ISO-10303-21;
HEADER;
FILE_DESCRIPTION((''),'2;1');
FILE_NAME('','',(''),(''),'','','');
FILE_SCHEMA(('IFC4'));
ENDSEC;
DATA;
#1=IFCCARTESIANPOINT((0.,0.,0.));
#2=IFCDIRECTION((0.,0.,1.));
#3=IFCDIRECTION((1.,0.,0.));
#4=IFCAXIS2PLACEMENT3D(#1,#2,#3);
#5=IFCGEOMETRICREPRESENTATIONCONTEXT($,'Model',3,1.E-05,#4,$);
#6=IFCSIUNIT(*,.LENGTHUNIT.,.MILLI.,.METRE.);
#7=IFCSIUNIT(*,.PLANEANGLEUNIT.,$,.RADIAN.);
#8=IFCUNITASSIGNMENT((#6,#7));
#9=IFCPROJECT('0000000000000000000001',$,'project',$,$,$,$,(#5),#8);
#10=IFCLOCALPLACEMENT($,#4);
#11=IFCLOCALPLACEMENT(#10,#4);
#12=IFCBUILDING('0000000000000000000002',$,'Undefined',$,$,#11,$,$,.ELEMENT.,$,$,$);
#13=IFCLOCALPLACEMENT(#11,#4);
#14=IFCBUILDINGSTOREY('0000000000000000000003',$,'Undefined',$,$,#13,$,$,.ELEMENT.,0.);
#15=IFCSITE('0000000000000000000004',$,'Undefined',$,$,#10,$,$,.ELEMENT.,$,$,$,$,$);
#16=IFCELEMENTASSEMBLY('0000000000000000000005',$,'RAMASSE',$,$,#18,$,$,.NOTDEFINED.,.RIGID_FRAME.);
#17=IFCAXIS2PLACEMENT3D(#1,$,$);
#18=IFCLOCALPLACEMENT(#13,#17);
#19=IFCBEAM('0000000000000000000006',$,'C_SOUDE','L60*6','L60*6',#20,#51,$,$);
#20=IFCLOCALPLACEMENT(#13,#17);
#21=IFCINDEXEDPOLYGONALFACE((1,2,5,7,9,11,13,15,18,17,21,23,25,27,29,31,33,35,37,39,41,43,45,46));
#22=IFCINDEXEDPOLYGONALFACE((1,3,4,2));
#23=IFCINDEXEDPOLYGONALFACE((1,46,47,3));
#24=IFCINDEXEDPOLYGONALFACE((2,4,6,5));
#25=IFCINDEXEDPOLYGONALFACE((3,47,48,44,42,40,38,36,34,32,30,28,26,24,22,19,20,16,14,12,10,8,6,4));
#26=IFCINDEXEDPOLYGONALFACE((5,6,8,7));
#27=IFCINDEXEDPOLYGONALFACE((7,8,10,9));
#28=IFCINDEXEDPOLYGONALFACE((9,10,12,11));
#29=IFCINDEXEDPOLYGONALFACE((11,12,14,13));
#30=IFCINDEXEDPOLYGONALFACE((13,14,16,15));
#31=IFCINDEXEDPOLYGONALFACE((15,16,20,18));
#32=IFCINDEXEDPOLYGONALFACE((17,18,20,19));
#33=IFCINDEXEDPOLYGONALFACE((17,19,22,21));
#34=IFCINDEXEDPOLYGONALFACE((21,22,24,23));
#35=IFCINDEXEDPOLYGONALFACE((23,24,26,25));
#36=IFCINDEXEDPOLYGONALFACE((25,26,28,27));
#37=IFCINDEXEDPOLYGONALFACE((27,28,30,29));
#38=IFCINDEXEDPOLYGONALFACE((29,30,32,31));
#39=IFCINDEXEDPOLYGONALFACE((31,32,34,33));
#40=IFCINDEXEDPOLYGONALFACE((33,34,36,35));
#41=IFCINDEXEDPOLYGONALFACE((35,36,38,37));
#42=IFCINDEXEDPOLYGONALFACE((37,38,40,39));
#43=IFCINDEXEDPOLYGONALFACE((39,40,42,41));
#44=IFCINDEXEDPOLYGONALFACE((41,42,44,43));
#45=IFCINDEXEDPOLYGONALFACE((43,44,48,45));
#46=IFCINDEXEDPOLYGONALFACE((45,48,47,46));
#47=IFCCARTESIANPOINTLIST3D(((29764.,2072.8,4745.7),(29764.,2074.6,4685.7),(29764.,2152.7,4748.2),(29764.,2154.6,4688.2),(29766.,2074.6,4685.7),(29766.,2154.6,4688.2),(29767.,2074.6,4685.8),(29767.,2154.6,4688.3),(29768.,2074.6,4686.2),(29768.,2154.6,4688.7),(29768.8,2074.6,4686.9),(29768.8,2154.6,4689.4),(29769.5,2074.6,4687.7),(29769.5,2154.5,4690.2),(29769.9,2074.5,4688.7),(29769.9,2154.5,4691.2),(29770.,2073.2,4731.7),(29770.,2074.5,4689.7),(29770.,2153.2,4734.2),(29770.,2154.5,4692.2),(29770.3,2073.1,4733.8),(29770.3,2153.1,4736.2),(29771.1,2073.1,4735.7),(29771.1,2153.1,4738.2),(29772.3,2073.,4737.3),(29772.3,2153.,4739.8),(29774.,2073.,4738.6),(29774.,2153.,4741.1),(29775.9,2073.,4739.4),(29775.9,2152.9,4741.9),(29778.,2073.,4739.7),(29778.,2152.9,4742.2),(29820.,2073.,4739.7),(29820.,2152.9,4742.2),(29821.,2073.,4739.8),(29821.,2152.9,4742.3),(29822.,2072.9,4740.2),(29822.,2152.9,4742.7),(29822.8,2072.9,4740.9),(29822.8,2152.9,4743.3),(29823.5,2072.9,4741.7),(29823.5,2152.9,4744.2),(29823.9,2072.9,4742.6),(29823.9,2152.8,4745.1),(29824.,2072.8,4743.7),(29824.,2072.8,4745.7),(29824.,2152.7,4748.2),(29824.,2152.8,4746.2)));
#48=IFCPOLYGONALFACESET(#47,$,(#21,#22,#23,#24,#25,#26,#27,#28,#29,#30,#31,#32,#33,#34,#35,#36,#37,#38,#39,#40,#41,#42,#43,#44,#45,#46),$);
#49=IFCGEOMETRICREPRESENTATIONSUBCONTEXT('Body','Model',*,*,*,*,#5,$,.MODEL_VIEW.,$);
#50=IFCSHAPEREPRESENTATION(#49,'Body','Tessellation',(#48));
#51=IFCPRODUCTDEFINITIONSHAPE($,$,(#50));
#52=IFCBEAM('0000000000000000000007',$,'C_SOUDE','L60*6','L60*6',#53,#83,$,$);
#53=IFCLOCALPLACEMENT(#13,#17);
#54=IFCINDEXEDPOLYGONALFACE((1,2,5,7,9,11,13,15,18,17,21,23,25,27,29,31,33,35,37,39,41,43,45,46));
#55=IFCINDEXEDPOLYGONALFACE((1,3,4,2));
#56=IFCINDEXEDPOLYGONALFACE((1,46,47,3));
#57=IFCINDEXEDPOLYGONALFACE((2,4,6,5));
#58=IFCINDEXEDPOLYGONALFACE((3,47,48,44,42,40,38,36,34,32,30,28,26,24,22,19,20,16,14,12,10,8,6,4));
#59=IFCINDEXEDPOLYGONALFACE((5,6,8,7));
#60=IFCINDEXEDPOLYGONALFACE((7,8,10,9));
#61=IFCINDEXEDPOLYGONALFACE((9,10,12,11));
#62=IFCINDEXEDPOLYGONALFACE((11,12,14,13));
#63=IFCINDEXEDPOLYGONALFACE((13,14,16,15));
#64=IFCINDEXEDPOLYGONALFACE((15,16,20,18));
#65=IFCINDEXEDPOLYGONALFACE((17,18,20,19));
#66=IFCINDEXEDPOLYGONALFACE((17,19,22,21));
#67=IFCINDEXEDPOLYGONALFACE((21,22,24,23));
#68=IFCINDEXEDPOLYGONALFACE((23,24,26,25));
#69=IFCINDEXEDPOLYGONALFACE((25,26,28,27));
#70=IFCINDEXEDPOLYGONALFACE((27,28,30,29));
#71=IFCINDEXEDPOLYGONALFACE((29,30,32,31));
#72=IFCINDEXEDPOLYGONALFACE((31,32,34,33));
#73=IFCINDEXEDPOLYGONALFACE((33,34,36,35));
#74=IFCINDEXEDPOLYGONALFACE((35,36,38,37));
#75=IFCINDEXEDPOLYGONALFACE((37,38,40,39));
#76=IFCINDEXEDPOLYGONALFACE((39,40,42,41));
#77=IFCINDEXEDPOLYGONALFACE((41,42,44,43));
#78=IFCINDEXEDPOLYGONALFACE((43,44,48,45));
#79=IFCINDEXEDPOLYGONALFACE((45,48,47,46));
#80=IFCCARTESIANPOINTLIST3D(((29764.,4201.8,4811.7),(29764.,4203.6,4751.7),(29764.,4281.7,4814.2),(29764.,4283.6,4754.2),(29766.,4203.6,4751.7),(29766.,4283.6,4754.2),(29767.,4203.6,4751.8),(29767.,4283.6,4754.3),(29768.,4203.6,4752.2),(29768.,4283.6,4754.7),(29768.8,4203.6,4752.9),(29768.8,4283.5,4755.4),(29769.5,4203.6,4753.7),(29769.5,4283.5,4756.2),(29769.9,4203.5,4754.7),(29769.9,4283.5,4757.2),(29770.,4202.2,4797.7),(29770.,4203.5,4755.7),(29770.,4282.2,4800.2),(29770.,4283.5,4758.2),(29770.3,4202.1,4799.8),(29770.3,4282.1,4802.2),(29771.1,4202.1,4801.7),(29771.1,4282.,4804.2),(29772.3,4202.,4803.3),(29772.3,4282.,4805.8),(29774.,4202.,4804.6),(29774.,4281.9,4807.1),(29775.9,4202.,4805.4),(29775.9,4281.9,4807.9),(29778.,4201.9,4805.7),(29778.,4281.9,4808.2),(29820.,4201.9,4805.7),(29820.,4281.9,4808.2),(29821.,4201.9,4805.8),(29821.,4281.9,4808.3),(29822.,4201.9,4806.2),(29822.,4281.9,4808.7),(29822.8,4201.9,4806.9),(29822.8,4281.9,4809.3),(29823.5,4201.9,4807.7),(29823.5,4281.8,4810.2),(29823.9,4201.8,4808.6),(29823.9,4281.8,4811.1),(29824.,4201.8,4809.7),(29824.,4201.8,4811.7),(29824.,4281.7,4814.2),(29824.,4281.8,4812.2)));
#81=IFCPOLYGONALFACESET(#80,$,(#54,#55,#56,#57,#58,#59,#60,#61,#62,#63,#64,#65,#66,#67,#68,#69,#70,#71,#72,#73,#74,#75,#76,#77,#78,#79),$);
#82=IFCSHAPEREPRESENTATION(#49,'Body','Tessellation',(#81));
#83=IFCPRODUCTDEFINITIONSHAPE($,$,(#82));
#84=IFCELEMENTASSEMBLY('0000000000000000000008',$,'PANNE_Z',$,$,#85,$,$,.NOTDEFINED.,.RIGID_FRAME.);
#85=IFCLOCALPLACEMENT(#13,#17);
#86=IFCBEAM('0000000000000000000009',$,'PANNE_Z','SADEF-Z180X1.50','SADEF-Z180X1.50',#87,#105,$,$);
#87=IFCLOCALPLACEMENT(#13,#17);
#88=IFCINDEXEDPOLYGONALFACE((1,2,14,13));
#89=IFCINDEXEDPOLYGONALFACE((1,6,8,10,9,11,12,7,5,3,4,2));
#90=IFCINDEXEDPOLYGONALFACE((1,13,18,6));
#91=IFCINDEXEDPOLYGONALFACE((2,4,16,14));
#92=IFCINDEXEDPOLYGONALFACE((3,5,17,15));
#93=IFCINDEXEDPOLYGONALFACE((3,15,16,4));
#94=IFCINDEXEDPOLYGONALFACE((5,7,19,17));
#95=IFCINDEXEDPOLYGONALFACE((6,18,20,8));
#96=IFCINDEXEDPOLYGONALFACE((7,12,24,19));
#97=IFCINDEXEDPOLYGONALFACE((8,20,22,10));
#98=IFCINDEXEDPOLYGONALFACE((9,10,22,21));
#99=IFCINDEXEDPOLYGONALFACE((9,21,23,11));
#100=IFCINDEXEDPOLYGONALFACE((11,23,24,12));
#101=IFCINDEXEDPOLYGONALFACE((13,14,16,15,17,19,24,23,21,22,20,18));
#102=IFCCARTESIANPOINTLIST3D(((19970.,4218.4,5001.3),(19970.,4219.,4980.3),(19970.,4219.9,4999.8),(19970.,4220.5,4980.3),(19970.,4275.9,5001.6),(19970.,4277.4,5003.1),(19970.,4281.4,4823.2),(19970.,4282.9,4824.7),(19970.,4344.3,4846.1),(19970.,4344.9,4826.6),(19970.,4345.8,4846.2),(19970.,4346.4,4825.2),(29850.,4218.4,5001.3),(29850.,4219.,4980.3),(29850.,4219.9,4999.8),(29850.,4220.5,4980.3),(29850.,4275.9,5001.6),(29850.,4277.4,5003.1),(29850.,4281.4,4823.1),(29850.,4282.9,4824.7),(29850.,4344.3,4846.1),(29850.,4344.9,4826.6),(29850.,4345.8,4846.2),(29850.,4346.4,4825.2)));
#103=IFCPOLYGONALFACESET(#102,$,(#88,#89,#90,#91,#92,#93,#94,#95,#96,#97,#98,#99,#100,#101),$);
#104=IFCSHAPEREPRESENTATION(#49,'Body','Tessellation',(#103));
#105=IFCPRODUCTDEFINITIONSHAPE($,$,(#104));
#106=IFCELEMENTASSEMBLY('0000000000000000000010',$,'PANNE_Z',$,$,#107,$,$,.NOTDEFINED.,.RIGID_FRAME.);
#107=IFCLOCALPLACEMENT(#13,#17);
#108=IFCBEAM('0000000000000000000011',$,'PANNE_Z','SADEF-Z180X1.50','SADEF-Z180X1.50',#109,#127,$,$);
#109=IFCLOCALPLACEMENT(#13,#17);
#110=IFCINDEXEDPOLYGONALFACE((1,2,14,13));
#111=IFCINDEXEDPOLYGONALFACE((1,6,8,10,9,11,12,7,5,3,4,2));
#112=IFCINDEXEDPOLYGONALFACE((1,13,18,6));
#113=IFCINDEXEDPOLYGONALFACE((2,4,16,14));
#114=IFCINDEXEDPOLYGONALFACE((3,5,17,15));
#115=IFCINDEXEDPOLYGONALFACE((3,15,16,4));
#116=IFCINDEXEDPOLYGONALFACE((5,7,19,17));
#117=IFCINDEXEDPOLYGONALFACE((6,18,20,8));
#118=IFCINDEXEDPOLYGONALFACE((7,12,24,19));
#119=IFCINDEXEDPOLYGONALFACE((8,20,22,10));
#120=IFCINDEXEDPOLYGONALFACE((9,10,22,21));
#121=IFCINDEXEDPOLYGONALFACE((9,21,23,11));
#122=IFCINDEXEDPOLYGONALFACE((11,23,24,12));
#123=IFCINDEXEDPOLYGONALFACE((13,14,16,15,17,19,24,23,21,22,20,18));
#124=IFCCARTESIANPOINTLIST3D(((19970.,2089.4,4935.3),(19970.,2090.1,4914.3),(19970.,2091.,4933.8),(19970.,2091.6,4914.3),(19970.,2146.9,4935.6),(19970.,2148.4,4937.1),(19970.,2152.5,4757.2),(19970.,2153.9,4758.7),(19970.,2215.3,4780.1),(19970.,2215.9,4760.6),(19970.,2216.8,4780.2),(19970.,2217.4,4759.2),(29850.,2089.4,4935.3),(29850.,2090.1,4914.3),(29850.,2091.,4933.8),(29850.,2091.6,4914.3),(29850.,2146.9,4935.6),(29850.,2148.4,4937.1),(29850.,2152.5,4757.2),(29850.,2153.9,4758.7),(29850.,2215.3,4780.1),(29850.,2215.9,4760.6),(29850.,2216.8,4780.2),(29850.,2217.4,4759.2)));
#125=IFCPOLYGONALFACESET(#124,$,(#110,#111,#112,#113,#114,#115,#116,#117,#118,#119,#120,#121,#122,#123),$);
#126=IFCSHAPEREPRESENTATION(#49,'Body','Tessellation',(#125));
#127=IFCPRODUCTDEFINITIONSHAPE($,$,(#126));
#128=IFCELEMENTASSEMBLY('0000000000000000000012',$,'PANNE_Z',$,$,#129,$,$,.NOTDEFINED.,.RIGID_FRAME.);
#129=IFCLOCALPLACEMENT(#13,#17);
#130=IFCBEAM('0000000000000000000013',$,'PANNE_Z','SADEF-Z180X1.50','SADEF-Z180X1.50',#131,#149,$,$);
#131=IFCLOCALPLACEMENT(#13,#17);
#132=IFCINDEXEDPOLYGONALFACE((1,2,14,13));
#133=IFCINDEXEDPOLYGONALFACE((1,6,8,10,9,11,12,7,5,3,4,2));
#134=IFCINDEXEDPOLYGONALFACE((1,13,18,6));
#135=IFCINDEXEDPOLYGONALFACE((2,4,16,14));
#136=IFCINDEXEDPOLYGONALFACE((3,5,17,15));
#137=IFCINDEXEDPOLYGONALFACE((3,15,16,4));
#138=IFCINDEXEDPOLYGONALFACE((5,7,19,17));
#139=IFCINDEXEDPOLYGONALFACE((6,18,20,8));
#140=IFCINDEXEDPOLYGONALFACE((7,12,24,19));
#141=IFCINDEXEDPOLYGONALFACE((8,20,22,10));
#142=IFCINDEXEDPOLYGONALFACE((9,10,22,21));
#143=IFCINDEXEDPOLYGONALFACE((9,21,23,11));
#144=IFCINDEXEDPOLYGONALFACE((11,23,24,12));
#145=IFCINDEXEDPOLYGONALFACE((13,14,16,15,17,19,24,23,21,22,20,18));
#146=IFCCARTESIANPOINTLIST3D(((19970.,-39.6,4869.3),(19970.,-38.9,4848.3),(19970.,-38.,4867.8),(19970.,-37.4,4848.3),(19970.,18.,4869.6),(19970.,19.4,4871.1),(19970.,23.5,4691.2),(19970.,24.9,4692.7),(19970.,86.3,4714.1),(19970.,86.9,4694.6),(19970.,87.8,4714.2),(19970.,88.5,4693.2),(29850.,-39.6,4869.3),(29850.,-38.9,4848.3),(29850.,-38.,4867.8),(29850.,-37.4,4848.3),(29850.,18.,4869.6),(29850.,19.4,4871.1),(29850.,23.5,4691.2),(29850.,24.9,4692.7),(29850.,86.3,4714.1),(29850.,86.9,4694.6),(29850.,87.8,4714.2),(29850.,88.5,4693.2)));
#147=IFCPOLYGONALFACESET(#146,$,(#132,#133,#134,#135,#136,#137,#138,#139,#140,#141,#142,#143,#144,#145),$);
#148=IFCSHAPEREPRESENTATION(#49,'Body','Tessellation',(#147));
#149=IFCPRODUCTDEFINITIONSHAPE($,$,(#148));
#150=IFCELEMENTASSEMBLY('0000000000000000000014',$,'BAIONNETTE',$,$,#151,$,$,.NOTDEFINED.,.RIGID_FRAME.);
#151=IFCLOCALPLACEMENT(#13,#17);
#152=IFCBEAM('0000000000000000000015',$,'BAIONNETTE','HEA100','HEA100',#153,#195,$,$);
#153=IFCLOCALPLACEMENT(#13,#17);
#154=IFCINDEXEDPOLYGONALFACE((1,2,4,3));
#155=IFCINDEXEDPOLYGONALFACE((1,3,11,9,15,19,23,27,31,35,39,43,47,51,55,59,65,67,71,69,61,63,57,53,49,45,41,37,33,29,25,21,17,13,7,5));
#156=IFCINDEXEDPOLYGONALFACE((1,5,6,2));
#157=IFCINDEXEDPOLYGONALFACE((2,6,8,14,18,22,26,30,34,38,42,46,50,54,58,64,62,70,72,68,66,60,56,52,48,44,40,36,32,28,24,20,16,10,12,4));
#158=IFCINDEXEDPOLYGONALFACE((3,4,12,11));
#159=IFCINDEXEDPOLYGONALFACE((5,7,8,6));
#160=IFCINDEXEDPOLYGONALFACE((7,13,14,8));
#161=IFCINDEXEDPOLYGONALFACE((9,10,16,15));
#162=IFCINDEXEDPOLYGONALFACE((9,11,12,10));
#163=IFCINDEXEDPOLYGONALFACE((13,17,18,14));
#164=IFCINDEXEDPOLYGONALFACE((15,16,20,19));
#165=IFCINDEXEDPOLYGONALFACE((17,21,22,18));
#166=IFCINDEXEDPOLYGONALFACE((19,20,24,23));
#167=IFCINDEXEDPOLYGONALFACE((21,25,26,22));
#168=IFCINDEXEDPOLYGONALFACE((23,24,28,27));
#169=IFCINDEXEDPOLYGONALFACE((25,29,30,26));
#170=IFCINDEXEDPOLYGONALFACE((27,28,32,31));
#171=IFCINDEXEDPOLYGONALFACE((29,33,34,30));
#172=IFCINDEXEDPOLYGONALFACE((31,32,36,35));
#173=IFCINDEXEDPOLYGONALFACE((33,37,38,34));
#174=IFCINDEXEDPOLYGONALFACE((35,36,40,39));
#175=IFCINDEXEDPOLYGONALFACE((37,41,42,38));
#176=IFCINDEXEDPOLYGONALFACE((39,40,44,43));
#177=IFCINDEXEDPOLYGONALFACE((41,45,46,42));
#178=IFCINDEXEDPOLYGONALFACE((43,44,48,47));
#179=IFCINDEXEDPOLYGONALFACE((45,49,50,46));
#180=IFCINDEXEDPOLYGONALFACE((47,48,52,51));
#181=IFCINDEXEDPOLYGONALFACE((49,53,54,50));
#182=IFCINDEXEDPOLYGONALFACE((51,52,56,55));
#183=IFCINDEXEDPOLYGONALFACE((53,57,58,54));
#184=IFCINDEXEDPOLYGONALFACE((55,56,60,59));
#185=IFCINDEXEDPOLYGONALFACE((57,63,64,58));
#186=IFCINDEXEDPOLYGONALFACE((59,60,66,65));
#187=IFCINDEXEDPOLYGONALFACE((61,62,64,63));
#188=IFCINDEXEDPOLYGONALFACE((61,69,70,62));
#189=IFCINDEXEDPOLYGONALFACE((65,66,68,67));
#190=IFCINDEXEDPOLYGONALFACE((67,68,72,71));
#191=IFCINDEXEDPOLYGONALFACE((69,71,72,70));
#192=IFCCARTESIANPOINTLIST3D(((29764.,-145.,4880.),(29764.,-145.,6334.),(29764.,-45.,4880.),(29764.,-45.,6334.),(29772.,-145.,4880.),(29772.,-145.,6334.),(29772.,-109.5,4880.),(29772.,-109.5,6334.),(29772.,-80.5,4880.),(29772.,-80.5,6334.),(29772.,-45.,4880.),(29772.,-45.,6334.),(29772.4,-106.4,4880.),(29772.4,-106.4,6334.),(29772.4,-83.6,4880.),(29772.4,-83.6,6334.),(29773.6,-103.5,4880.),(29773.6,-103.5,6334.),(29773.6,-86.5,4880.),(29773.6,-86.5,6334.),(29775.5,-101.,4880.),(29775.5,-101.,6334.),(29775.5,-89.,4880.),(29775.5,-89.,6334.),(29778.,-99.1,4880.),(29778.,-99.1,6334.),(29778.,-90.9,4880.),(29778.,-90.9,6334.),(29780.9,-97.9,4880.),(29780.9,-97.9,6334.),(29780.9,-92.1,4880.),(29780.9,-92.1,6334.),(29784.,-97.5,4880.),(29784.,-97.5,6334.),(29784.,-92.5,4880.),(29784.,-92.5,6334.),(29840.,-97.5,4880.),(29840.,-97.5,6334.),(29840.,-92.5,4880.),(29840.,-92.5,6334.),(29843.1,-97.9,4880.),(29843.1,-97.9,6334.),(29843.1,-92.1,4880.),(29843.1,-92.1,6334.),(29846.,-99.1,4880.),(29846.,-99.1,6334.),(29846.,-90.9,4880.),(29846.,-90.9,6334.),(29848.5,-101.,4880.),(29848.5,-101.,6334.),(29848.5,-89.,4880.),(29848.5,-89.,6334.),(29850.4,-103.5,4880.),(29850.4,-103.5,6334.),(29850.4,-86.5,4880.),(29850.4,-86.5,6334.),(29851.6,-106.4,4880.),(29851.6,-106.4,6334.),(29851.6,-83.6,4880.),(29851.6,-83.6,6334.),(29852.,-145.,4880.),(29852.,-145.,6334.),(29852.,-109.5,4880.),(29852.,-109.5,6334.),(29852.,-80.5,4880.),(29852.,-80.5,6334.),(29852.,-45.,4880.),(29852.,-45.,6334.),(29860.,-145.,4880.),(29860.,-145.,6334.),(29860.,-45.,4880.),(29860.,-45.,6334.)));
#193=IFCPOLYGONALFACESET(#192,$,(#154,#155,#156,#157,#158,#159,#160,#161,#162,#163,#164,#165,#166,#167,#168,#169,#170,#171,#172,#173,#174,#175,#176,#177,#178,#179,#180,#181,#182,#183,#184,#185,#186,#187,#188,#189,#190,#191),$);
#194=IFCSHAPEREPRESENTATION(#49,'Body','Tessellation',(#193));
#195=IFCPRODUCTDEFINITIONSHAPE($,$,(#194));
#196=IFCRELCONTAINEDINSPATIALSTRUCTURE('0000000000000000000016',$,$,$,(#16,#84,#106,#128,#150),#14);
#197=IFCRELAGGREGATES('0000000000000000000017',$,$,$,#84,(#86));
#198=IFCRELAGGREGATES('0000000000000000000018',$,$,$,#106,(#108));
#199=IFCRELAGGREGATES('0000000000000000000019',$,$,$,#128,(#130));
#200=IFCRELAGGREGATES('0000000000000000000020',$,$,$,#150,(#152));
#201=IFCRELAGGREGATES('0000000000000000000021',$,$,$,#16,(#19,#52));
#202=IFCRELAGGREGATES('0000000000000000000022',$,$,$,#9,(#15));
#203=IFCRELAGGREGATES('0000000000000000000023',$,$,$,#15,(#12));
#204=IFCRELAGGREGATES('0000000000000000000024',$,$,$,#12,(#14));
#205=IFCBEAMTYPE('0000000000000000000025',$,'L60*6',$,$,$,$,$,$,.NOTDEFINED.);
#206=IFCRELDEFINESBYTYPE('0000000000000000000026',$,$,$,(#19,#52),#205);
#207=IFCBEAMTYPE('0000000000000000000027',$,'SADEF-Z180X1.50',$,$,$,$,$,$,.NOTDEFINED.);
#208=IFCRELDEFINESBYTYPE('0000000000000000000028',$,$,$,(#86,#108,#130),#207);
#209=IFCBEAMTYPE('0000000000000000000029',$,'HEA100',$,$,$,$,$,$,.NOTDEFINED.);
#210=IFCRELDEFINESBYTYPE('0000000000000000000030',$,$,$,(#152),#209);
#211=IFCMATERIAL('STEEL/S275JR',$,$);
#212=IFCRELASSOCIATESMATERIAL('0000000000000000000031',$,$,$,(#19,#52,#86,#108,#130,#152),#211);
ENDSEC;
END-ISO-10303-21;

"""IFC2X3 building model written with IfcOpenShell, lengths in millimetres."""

from ifc_helpers import new_model, si_unit, frame, origin_with_axes, origin_2d_with_axis, place, context, subcontext, project, spatial, polyline, i_section, l_section, outline, extrude, clip, halfspace, material, type_object, element, aggregate, save


model = new_model("IFC2X3")

# Units and contexts
model_context = context("Model", 3, precision=1e-05, world=origin_with_axes())
body_context = subcontext(model_context, "Body", "Model", "MODEL_VIEW")
ifc_project = project(units=[si_unit("LENGTHUNIT", "METRE", prefix="MILLI"), si_unit("PLANEANGLEUNIT", "RADIAN")], contexts=[model_context])

# Site, building, storey
site_placement = place(None, origin_with_axes())
site = spatial("IfcSite", under=ifc_project, at=site_placement, Name="Undefined", CompositionType="ELEMENT")
building_placement = place(site_placement, origin_with_axes())
building = spatial("IfcBuilding", under=site, at=building_placement, Name="Undefined", CompositionType="ELEMENT")
storey_placement = place(building_placement, origin_with_axes())
storey = spatial("IfcBuildingStorey", under=building, at=storey_placement, Name="Undefined", CompositionType="ELEMENT", Elevation=0.0)

# Element assembly, beams
assembly_1_placement = place(storey_placement, origin_with_axes())
assembly_1 = element("IfcElementAssembly", 1, at=assembly_1_placement, inside=storey, Name="RAMASSE", AssemblyPlace="NOTDEFINED", PredefinedType="RIGID_FRAME")
ifc_material_1 = material(Name="STEEL/S275JR")
beam_type_1 = type_object("IfcBeamType", Name="L60*6", PredefinedType="NOTDEFINED")
beam_1_placement = place(assembly_1_placement, frame((29794.0, 2073.7, 4715.7), z_axis=(1.0, 0.0, 0.0), x_axis=(0.0, 0.99952, 0.030986)))
beam_1 = element("IfcBeam", 2, at=beam_1_placement, type_object=beam_type_1, material=ifc_material_1, Name="C_SOUDE", Description="L60*6", ObjectType="L60*6", context=body_context, shape_type="SweptSolid", body=[
    extrude(l_section(Depth=60.0, Width=60.0, Thickness=6.0, FilletRadius=8.0, EdgeRadius=4.0, at=origin_2d_with_axis()), frame((80.0, 0.0, 0.0), z_axis=(-1.0, 0.0, 0.0), x_axis=(0.0, -1.0, 0.0)), (0.0, 0.0, 1.0), 80.0),
])
beam_2_placement = place(assembly_1_placement, frame((29794.0, 4202.7, 4781.7), z_axis=(1.0, 0.0, 0.0), x_axis=(0.0, 0.99952, 0.030986)))
beam_2 = element("IfcBeam", 3, at=beam_2_placement, type_object=beam_type_1, material=ifc_material_1, Name="C_SOUDE", Description="L60*6", ObjectType="L60*6", context=body_context, shape_type="SweptSolid", body=[
    extrude(l_section(Depth=60.0, Width=60.0, Thickness=6.0, FilletRadius=8.0, EdgeRadius=4.0, at=origin_2d_with_axis()), frame((80.0, 0.0, 0.0), z_axis=(-1.0, 0.0, 0.0), x_axis=(0.0, -1.0, 0.0)), (0.0, 0.0, 1.0), 80.0),
])

# Element assemblies, beams
assembly_2_placement = place(storey_placement, origin_with_axes())
assembly_2 = element("IfcElementAssembly", 4, at=assembly_2_placement, inside=storey, Name="PANNE_Z", AssemblyPlace="NOTDEFINED", PredefinedType="RIGID_FRAME")
beam_type_2 = type_object("IfcBeamType", Name="SADEF-Z180X1.50", PredefinedType="NOTDEFINED")
beam_3_placement = place(assembly_2_placement, frame((29850.0, 4279.4, 4913.1), z_axis=(0.0, -0.031032, 0.999518), x_axis=(-1.0, 0.0, 0.0)))
beam_3 = element("IfcBeam", 5, at=beam_3_placement, type_object=beam_type_2, material=ifc_material_1, Name="PANNE_Z", Description="SADEF-Z180X1.50", ObjectType="SADEF-Z180X1.50", context=body_context, shape_type="SweptSolid", body=[
    extrude(outline(polyline([(-56.7, 69.0), (-58.2, 69.0), (-58.2, 90.0), (0.8, 90.0), (0.7, -88.5), (62.7, -88.5), (62.7, -69.0), (64.2, -69.0), (64.2, -90.0), (-0.8, -90.0), (-0.7, 88.5), (-56.7, 88.5), (-56.7, 69.0)])), frame((9880.0, 0.0, 0.0), z_axis=(-1.0, 0.0, 0.0), x_axis=(0.0, -1.0, 0.0)), (0.0, 0.0, 1.0), 9880.0),
])
aggregate(assembly_2, [beam_3])
assembly_3_placement = place(storey_placement, origin_with_axes())
assembly_3 = element("IfcElementAssembly", 6, at=assembly_3_placement, inside=storey, Name="PANNE_Z", AssemblyPlace="NOTDEFINED", PredefinedType="RIGID_FRAME")
beam_4_placement = place(assembly_3_placement, frame((29850.0, 2150.4, 4847.1), z_axis=(0.0, -0.031032, 0.999518), x_axis=(-1.0, 0.0, 0.0)))
beam_4 = element("IfcBeam", 7, at=beam_4_placement, type_object=beam_type_2, material=ifc_material_1, Name="PANNE_Z", Description="SADEF-Z180X1.50", ObjectType="SADEF-Z180X1.50", context=body_context, shape_type="SweptSolid", body=[
    extrude(outline(polyline([(-56.7, 69.0), (-58.2, 69.0), (-58.2, 90.0), (0.8, 90.0), (0.7, -88.5), (62.7, -88.5), (62.7, -69.0), (64.2, -69.0), (64.2, -90.0), (-0.8, -90.0), (-0.7, 88.5), (-56.7, 88.5), (-56.7, 69.0)])), frame((9880.0, 0.0, 0.0), z_axis=(-1.0, 0.0, 0.0), x_axis=(0.0, -1.0, 0.0)), (0.0, 0.0, 1.0), 9880.0),
])
aggregate(assembly_3, [beam_4])
assembly_4_placement = place(storey_placement, origin_with_axes())
assembly_4 = element("IfcElementAssembly", 8, at=assembly_4_placement, inside=storey, Name="PANNE_Z", AssemblyPlace="NOTDEFINED", PredefinedType="RIGID_FRAME")
beam_5_placement = place(assembly_4_placement, frame((29850.0, 21.4, 4781.1), z_axis=(0.0, -0.031032, 0.999518), x_axis=(-1.0, 0.0, 0.0)))
beam_5 = element("IfcBeam", 9, at=beam_5_placement, type_object=beam_type_2, material=ifc_material_1, Name="PANNE_Z", Description="SADEF-Z180X1.50", ObjectType="SADEF-Z180X1.50", context=body_context, shape_type="SweptSolid", body=[
    extrude(outline(polyline([(-56.7, 69.0), (-58.2, 69.0), (-58.2, 90.0), (0.8, 90.0), (0.7, -88.5), (62.7, -88.5), (62.7, -69.0), (64.2, -69.0), (64.2, -90.0), (-0.8, -90.0), (-0.7, 88.5), (-56.7, 88.5), (-56.7, 69.0)])), frame((9880.0, 0.0, 0.0), z_axis=(-1.0, 0.0, 0.0), x_axis=(0.0, -1.0, 0.0)), (0.0, 0.0, 1.0), 9880.0),
])
aggregate(assembly_4, [beam_5])
assembly_5_placement = place(storey_placement, origin_with_axes())
assembly_5 = element("IfcElementAssembly", 10, at=assembly_5_placement, inside=storey, Name="BAIONNETTE", AssemblyPlace="NOTDEFINED", PredefinedType="RIGID_FRAME")
beam_type_3 = type_object("IfcBeamType", Name="HEA100", PredefinedType="NOTDEFINED")
beam_6_placement = place(assembly_5_placement, frame((29812.0, -95.0, 6300.0), z_axis=(1.0, 0.0, 0.0), x_axis=(0.0, 0.0, -1.0)))
beam_6 = element("IfcBeam", 11, at=beam_6_placement, type_object=beam_type_3, material=ifc_material_1, Name="BAIONNETTE", Description="HEA100", ObjectType="HEA100", context=body_context, shape_type="Clipping", body=[
    clip(extrude(i_section(OverallWidth=100.0, OverallDepth=96.0, WebThickness=5.0, FlangeThickness=8.0, FilletRadius=12.0, at=origin_2d_with_axis()), frame((1420.0, 0.0, 0.0), z_axis=(-1.0, 0.0, 0.0), x_axis=(0.0, -1.0, 0.0)), (0.0, 0.0, 1.0), 1454.0), halfspace(frame((-34.0, 53.6, -48.0), z_axis=(1.0, 0.0, 0.0), x_axis=(0.0, 0.0, -1.0)), True)),
])

aggregate(assembly_5, [beam_6])
aggregate(assembly_1, [beam_1, beam_2])

save(model, "model.ifc")
